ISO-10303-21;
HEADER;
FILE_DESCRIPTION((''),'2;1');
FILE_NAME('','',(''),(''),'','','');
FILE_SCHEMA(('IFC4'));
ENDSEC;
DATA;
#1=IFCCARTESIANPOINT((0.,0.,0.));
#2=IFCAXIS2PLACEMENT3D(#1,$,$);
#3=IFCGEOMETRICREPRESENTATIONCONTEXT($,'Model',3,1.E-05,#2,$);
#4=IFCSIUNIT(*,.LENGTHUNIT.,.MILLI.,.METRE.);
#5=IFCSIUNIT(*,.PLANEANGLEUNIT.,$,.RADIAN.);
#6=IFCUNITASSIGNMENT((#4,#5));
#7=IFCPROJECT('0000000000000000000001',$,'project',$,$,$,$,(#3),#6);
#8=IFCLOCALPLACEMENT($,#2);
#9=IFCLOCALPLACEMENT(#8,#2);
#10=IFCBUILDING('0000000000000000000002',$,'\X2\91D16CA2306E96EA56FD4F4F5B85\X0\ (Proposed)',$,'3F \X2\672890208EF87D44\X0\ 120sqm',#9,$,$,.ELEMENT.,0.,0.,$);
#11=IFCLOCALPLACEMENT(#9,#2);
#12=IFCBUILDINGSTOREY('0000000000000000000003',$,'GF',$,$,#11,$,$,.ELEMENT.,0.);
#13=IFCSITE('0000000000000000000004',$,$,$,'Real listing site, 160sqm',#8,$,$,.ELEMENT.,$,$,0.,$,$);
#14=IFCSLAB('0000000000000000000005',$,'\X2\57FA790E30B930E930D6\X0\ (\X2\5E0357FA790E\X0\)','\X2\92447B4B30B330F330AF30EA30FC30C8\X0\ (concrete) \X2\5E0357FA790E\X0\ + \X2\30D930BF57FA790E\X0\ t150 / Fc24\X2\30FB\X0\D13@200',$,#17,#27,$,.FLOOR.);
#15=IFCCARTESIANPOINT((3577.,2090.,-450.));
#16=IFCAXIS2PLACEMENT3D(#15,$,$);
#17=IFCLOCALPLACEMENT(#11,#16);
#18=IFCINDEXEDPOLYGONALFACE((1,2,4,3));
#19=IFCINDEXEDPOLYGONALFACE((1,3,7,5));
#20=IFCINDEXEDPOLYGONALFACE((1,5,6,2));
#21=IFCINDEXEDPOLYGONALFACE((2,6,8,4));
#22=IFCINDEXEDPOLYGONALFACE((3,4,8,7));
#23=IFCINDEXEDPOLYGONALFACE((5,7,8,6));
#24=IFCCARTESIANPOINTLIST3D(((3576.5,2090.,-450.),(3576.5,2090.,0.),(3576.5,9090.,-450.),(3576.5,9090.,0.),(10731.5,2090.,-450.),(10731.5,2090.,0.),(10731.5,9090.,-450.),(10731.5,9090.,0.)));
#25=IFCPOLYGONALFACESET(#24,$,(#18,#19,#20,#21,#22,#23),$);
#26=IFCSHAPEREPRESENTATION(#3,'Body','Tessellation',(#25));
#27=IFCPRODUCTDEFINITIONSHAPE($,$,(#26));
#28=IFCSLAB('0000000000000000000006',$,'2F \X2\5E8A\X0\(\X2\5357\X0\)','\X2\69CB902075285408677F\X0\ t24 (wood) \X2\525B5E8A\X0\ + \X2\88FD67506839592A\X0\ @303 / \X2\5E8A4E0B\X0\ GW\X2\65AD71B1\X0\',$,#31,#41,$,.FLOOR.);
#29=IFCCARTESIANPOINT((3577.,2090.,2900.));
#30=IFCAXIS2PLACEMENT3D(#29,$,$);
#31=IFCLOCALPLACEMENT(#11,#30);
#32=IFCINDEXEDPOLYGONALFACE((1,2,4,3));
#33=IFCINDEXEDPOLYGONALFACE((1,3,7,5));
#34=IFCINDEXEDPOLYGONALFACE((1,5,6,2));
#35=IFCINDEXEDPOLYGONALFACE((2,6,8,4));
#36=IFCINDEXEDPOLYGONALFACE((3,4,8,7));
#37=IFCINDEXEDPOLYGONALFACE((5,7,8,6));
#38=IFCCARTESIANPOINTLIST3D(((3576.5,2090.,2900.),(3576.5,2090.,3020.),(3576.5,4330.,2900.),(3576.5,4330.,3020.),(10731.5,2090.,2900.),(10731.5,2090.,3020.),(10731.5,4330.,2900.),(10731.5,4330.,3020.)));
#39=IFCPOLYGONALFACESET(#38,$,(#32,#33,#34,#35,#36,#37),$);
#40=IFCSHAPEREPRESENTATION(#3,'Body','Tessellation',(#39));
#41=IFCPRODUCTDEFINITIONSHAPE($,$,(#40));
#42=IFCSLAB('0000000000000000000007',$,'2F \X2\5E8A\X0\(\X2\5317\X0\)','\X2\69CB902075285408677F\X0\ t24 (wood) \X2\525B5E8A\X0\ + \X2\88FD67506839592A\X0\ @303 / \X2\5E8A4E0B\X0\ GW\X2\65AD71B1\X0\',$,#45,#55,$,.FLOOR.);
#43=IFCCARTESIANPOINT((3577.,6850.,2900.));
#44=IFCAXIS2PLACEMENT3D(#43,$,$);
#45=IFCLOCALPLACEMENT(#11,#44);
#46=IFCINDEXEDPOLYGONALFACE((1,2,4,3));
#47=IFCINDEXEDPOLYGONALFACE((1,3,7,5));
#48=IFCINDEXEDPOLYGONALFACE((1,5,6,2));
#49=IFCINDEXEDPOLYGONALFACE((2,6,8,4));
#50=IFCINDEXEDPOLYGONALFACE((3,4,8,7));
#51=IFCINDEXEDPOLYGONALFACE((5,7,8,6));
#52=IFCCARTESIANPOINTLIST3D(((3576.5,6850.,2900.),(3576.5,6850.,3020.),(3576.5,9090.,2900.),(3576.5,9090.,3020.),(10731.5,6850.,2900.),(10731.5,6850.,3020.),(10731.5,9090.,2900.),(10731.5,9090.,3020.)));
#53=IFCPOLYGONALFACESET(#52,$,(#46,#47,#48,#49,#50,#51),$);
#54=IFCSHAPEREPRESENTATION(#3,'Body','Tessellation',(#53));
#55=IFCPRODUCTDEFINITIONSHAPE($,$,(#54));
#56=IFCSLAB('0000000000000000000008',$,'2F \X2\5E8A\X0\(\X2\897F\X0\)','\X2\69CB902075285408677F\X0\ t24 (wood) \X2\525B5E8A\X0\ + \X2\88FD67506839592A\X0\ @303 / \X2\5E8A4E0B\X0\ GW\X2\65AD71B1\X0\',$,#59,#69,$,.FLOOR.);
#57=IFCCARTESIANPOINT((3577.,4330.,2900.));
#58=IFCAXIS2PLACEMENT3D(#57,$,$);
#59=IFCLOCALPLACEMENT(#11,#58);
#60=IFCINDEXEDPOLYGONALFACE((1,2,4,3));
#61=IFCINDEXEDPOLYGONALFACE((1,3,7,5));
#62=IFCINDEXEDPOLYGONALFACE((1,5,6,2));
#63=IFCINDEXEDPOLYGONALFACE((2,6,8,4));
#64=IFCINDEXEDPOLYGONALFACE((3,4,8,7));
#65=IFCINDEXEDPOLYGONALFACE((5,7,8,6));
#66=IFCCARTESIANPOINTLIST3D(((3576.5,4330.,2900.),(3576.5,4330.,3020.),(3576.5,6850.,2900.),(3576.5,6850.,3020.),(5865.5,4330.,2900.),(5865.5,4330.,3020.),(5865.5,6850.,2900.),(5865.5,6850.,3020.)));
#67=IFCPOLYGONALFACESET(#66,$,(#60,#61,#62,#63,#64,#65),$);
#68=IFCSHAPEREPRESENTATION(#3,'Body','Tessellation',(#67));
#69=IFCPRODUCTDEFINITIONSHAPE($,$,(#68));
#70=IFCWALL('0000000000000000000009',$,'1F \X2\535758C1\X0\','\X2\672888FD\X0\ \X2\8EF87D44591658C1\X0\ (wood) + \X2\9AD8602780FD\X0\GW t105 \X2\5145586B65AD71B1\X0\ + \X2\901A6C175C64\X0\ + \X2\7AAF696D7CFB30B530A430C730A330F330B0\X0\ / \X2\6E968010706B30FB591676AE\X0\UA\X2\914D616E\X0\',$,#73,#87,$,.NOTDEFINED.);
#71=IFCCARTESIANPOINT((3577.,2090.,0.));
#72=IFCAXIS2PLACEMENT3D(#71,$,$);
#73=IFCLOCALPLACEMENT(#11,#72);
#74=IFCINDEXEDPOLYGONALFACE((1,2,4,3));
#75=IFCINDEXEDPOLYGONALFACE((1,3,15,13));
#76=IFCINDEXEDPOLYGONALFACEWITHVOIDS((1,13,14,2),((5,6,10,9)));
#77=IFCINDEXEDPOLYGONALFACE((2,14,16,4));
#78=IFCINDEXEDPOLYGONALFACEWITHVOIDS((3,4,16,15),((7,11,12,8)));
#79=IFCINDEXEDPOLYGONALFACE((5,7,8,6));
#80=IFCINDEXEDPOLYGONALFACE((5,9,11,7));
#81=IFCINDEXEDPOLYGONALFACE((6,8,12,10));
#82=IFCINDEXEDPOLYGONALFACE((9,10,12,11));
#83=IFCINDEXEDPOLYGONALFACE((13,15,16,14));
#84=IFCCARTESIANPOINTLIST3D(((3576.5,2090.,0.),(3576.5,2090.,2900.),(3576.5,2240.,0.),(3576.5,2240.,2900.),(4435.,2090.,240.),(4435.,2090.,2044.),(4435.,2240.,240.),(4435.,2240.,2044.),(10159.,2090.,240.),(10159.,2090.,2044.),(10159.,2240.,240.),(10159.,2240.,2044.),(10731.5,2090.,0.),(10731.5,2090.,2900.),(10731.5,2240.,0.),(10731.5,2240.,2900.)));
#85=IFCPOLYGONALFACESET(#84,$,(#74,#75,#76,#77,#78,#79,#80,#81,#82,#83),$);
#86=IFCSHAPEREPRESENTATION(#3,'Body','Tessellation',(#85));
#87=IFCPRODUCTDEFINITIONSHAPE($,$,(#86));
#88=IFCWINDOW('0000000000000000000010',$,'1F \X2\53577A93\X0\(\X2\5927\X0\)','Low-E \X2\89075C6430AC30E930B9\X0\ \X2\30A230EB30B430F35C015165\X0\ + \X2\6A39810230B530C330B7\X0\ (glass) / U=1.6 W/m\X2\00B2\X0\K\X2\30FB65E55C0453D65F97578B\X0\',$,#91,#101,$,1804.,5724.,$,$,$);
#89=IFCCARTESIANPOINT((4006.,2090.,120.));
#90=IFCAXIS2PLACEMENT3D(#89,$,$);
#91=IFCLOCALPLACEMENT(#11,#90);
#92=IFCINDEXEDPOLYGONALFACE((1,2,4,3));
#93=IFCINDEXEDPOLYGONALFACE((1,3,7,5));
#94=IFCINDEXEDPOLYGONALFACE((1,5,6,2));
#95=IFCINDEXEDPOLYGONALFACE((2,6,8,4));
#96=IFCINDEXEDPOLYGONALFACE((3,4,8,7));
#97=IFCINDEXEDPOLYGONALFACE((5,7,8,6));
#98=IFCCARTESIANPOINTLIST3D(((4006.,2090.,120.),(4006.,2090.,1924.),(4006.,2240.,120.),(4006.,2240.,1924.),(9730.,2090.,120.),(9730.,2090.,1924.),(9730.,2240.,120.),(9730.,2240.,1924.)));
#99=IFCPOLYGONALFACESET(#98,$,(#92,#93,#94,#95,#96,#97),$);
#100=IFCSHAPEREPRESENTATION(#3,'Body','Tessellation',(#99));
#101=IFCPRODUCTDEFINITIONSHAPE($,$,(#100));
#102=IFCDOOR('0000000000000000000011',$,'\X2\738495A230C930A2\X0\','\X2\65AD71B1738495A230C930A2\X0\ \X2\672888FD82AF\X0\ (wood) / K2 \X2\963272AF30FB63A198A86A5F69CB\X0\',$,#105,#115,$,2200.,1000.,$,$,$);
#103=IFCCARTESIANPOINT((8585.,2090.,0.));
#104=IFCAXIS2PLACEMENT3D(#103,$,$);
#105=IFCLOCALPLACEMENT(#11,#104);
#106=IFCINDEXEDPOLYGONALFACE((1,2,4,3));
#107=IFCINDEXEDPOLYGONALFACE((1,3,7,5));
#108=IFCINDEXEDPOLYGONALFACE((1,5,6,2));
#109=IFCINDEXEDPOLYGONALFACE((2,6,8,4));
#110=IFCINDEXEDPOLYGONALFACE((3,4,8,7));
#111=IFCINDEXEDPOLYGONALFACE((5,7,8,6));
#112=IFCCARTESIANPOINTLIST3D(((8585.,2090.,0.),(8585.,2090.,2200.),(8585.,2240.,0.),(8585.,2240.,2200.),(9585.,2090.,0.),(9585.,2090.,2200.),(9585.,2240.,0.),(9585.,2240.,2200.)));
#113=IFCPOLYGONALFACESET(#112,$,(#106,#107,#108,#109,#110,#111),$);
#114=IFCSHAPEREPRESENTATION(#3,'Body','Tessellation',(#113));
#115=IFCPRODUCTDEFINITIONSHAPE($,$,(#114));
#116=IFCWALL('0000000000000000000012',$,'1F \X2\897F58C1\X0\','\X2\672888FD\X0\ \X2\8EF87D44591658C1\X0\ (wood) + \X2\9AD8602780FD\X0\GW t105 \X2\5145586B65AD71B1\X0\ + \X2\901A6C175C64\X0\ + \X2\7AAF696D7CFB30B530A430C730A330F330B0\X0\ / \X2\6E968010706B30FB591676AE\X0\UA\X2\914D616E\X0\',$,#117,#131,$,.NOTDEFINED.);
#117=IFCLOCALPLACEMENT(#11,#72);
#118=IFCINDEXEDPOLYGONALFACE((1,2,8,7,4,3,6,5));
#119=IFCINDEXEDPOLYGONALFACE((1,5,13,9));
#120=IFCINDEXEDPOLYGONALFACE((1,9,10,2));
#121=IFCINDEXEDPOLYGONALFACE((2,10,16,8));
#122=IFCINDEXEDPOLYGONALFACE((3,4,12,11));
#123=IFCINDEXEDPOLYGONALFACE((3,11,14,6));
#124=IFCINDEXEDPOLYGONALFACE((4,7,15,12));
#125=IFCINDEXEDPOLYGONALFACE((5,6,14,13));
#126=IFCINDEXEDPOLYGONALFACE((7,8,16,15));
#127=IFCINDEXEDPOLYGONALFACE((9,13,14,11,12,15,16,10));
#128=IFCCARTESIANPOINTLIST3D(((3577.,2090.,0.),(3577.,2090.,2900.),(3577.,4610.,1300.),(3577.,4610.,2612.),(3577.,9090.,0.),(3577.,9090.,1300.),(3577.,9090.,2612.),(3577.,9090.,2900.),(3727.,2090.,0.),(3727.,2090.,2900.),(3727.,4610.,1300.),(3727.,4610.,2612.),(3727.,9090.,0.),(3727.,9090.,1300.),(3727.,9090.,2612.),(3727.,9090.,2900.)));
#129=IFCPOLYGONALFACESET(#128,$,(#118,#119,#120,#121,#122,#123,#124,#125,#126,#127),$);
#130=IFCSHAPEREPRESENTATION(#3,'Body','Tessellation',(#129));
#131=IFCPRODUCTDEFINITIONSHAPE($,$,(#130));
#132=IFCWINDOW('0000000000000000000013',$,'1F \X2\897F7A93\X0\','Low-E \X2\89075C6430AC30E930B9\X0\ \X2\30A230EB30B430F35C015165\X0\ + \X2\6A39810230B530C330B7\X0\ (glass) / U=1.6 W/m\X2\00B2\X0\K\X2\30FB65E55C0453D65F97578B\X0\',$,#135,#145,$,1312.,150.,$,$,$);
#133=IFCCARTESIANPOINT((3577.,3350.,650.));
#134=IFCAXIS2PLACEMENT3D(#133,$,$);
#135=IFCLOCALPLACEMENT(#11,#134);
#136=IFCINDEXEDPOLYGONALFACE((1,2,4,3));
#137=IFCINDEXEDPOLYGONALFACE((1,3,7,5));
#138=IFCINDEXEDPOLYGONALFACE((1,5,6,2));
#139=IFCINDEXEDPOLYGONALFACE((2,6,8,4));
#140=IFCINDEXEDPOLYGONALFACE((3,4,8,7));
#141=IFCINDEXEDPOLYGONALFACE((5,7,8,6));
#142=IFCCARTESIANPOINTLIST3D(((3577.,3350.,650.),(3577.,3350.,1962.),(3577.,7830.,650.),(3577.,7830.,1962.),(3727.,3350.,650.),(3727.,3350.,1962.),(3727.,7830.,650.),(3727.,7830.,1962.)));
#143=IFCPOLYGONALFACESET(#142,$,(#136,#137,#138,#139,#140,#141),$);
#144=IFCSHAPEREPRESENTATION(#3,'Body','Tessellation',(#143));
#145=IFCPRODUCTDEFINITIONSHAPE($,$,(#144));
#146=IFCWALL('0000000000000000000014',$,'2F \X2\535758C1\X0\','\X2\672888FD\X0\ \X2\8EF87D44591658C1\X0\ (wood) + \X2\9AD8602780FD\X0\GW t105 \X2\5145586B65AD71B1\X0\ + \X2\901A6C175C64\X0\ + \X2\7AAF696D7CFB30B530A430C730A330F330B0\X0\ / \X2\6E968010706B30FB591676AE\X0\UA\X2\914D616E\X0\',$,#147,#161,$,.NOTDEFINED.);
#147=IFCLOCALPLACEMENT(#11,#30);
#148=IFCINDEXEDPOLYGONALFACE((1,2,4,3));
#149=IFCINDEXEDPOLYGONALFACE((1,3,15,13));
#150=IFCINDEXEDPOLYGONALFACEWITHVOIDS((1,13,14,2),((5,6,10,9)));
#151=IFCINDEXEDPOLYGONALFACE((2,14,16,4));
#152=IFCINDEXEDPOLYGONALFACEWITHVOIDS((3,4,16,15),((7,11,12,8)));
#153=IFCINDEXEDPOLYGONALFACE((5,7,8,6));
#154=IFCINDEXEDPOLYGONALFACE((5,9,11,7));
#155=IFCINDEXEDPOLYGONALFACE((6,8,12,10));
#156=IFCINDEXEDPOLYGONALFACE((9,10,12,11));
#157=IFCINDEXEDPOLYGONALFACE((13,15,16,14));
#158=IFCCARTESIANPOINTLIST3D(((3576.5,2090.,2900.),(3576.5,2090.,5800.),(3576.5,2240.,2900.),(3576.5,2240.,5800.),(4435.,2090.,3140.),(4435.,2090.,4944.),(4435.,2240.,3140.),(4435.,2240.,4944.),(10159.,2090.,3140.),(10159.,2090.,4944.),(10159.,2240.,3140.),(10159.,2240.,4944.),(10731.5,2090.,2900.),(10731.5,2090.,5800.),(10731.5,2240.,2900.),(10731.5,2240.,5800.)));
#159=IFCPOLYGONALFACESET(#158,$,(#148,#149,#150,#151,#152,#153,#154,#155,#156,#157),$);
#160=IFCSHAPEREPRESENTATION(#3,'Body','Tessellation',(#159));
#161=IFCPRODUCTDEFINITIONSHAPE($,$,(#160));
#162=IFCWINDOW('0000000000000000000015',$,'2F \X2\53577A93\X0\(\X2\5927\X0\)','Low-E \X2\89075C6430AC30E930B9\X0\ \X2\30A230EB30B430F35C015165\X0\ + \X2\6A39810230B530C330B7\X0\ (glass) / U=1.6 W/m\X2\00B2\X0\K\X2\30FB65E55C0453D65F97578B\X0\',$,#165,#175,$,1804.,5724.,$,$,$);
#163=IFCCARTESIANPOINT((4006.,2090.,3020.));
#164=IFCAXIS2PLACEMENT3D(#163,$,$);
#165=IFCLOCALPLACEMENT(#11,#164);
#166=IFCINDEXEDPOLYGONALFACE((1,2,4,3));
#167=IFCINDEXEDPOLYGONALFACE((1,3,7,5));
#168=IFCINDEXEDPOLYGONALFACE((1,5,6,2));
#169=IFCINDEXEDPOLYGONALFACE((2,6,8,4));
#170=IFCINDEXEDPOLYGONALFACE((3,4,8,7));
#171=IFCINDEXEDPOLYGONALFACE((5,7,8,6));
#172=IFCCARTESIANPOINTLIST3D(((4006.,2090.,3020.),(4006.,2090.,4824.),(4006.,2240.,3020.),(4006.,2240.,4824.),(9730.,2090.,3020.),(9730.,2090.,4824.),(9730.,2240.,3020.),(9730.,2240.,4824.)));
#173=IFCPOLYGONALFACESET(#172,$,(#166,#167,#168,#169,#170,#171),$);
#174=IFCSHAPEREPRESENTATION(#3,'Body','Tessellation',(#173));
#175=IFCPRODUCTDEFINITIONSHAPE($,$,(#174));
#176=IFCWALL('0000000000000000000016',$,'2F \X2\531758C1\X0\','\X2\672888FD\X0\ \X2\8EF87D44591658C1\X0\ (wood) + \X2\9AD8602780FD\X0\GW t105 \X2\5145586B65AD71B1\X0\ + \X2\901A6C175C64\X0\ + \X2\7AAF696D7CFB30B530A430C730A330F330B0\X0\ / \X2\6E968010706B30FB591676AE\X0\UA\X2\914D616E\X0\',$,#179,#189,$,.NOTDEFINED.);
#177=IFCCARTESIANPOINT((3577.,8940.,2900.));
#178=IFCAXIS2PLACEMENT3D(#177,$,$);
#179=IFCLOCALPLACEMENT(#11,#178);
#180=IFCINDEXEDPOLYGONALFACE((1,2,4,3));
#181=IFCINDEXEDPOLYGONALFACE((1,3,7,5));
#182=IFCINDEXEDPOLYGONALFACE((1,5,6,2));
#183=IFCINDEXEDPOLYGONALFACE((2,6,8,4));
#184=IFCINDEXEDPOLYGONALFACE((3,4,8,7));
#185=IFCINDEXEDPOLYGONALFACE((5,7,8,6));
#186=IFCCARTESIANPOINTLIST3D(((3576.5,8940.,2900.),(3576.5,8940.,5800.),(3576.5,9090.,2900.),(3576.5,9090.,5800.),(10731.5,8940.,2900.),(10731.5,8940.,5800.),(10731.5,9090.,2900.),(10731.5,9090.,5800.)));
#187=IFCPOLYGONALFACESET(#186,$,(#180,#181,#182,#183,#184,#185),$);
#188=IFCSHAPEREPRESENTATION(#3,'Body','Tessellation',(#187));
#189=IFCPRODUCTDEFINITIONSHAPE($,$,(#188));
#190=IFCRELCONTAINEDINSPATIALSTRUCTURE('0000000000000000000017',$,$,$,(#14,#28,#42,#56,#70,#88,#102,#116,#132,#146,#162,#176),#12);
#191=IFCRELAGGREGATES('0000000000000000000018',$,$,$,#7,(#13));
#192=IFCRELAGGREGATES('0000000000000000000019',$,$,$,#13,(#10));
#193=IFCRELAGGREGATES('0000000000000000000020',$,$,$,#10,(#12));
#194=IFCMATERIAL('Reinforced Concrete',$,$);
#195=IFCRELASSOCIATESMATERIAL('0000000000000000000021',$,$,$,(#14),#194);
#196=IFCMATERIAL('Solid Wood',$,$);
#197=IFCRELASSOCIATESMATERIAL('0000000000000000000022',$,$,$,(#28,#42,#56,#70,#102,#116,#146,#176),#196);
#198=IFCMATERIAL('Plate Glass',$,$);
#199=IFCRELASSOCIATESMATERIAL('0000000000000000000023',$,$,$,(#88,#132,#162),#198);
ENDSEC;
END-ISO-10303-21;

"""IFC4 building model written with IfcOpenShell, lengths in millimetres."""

from ifc_helpers import new_model, si_unit, frame, frame_2d, origin, place, context, project, spatial, rectangle, extrude, material, element, fill, save


model = new_model("IFC4")

# Units and contexts
model_context = context("Model", 3, precision=1e-05, world=origin())
ifc_project = project(units=[si_unit("LENGTHUNIT", "METRE", prefix="MILLI"), si_unit("PLANEANGLEUNIT", "RADIAN")], contexts=[model_context])

# Site, building, storey
site_placement = place(None, origin())
site = spatial("IfcSite", under=ifc_project, at=site_placement, ObjectType="Real listing site, 160sqm", CompositionType="ELEMENT", RefElevation=0.0)
building_placement = place(site_placement, origin())
building = spatial("IfcBuilding", under=site, at=building_placement, Name="金沢の雪国住宅 (Proposed)", ObjectType="3F 木造軸組 120sqm", CompositionType="ELEMENT", ElevationOfRefHeight=0.0, ElevationOfTerrain=0.0)
storey_placement = place(building_placement, origin())
storey = spatial("IfcBuildingStorey", under=building, at=storey_placement, Name="GF", CompositionType="ELEMENT", Elevation=0.0)

# Slabs
ifc_material_1 = material(Name="Reinforced Concrete")
slab_1_placement = place(storey_placement, frame((3577.0, 2090.0, -450.0)))
element("IfcSlab", 1, at=slab_1_placement, inside=storey, material=ifc_material_1, Name="基礎スラブ (布基礎)", Description="鉄筋コンクリート (concrete) 布基礎 + ベタ基礎 t150 / Fc24・D13@200", PredefinedType="FLOOR", context=model_context, shape_type="SweptSolid", body=[
    extrude(rectangle(XDim=7155.0, YDim=7000.0, at=frame_2d((3577.0, 3500.0))), frame((3577.0, 2090.0, -450.0)), (0.0, 0.0, 1.0), 450.0),
])
ifc_material_2 = material(Name="Solid Wood")
slab_2_placement = place(storey_placement, frame((3577.0, 2090.0, 2900.0)))
element("IfcSlab", 2, at=slab_2_placement, inside=storey, material=ifc_material_2, Name="2F 床(南)", Description="構造用合板 t24 (wood) 剛床 + 製材根太 @303 / 床下 GW断熱", PredefinedType="FLOOR", context=model_context, shape_type="SweptSolid", body=[
    extrude(rectangle(XDim=7155.0, YDim=2240.0, at=frame_2d((3577.0, 1120.0))), frame((3577.0, 2090.0, 2900.0)), (0.0, 0.0, 1.0), 120.0),
])
slab_3_placement = place(storey_placement, frame((3577.0, 6850.0, 2900.0)))
element("IfcSlab", 3, at=slab_3_placement, inside=storey, material=ifc_material_2, Name="2F 床(北)", Description="構造用合板 t24 (wood) 剛床 + 製材根太 @303 / 床下 GW断熱", PredefinedType="FLOOR", context=model_context, shape_type="SweptSolid", body=[
    extrude(rectangle(XDim=7155.0, YDim=2240.0, at=frame_2d((3577.0, 1120.0))), frame((3577.0, 6850.0, 2900.0)), (0.0, 0.0, 1.0), 120.0),
])
slab_4_placement = place(storey_placement, frame((3577.0, 4330.0, 2900.0)))
element("IfcSlab", 4, at=slab_4_placement, inside=storey, material=ifc_material_2, Name="2F 床(西)", Description="構造用合板 t24 (wood) 剛床 + 製材根太 @303 / 床下 GW断熱", PredefinedType="FLOOR", context=model_context, shape_type="SweptSolid", body=[
    extrude(rectangle(XDim=2289.0, YDim=2520.0, at=frame_2d((1144.0, 1260.0))), frame((3577.0, 4330.0, 2900.0)), (0.0, 0.0, 1.0), 120.0),
])

# Wall, openings, window, door
wall_1_placement = place(storey_placement, frame((3577.0, 2090.0, 0.0)))
wall_1 = element("IfcWall", 5, at=wall_1_placement, inside=storey, material=ifc_material_2, Name="1F 南壁", Description="木製 軸組外壁 (wood) + 高性能GW t105 充填断熱 + 通気層 + 窯業系サイディング / 準耐火・外皮UA配慮", PredefinedType="NOTDEFINED", context=model_context, shape_type="SweptSolid", body=[
    extrude(rectangle(XDim=7155.0, YDim=150.0, at=frame_2d((3577.0, 75.0))), frame((3577.0, 2090.0, 0.0)), (0.0, 0.0, 1.0), 2900.0),
])
opening_1_placement = place(storey_placement, frame((4006.0, 2090.0, 120.0)))
opening_1 = element("IfcOpeningElement", 6, at=opening_1_placement, cuts=wall_1, PredefinedType="NOTDEFINED", context=model_context, shape_type="SweptSolid", body=[
    extrude(rectangle(XDim=5724.0, YDim=150.0, at=frame_2d((2862.0, 75.0))), frame((4006.0, 2090.0, 120.0)), (0.0, 0.0, 1.0), 1804.0),
])
opening_2_placement = place(storey_placement, frame((8585.0, 2090.0, 0.0)))
opening_2 = element("IfcOpeningElement", 7, at=opening_2_placement, cuts=wall_1, PredefinedType="NOTDEFINED", context=model_context, shape_type="SweptSolid", body=[
    extrude(rectangle(XDim=1000.0, YDim=150.0, at=frame_2d((500.0, 75.0))), frame((8585.0, 2090.0, 0.0)), (0.0, 0.0, 1.0), 2200.0),
])
ifc_material_3 = material(Name="Plate Glass")
window_1_placement = place(storey_placement, frame((4006.0, 2090.0, 120.0)))
window_1 = element("IfcWindow", 8, at=window_1_placement, inside=storey, material=ifc_material_3, Name="1F 南窓(大)", Description="Low-E 複層ガラス アルゴン封入 + 樹脂サッシ (glass) / U=1.6 W/m²K・日射取得型", OverallHeight=1804.0, OverallWidth=5724.0, context=model_context, shape_type="SweptSolid", body=[
    extrude(rectangle(XDim=5724.0, YDim=150.0, at=frame_2d((2862.0, 75.0))), frame((4006.0, 2090.0, 120.0)), (0.0, 0.0, 1.0), 1804.0),
])
fill(opening_1, window_1)
door_placement = place(storey_placement, frame((8585.0, 2090.0, 0.0)))
door = element("IfcDoor", 9, at=door_placement, inside=storey, material=ifc_material_2, Name="玄関ドア", Description="断熱玄関ドア 木製芯 (wood) / K2 防犯・採風機構", OverallHeight=2200.0, OverallWidth=1000.0, context=model_context, shape_type="SweptSolid", body=[
    extrude(rectangle(XDim=1000.0, YDim=150.0, at=frame_2d((500.0, 75.0))), frame((8585.0, 2090.0, 0.0)), (0.0, 0.0, 1.0), 2200.0),
])
fill(opening_2, door)

# Walls, openings, windows
wall_2_placement = place(storey_placement, frame((3577.0, 2090.0, 0.0)))
wall_2 = element("IfcWall", 10, at=wall_2_placement, inside=storey, material=ifc_material_2, Name="1F 西壁", Description="木製 軸組外壁 (wood) + 高性能GW t105 充填断熱 + 通気層 + 窯業系サイディング / 準耐火・外皮UA配慮", PredefinedType="NOTDEFINED", context=model_context, shape_type="SweptSolid", body=[
    extrude(rectangle(XDim=150.0, YDim=7000.0, at=frame_2d((75.0, 3500.0))), frame((3577.0, 2090.0, 0.0)), (0.0, 0.0, 1.0), 2900.0),
])
opening_3_placement = place(storey_placement, frame((3577.0, 3350.0, 650.0)))
opening_3 = element("IfcOpeningElement", 11, at=opening_3_placement, cuts=wall_2, PredefinedType="NOTDEFINED", context=model_context, shape_type="SweptSolid", body=[
    extrude(rectangle(XDim=150.0, YDim=4480.0, at=frame_2d((75.0, 2240.0))), frame((3577.0, 3350.0, 650.0)), (0.0, 0.0, 1.0), 1312.0),
])
window_2_placement = place(storey_placement, frame((3577.0, 3350.0, 650.0)))
window_2 = element("IfcWindow", 12, at=window_2_placement, inside=storey, material=ifc_material_3, Name="1F 西窓", Description="Low-E 複層ガラス アルゴン封入 + 樹脂サッシ (glass) / U=1.6 W/m²K・日射取得型", OverallHeight=1312.0, OverallWidth=150.0, context=model_context, shape_type="SweptSolid", body=[
    extrude(rectangle(XDim=150.0, YDim=4480.0, at=frame_2d((75.0, 2240.0))), frame((3577.0, 3350.0, 650.0)), (0.0, 0.0, 1.0), 1312.0),
])
fill(opening_3, window_2)
wall_3_placement = place(storey_placement, frame((3577.0, 2090.0, 2900.0)))
wall_3 = element("IfcWall", 13, at=wall_3_placement, inside=storey, material=ifc_material_2, Name="2F 南壁", Description="木製 軸組外壁 (wood) + 高性能GW t105 充填断熱 + 通気層 + 窯業系サイディング / 準耐火・外皮UA配慮", PredefinedType="NOTDEFINED", context=model_context, shape_type="SweptSolid", body=[
    extrude(rectangle(XDim=7155.0, YDim=150.0, at=frame_2d((3577.0, 75.0))), frame((3577.0, 2090.0, 2900.0)), (0.0, 0.0, 1.0), 2900.0),
])
opening_4_placement = place(storey_placement, frame((4006.0, 2090.0, 3020.0)))
opening_4 = element("IfcOpeningElement", 14, at=opening_4_placement, cuts=wall_3, PredefinedType="NOTDEFINED", context=model_context, shape_type="SweptSolid", body=[
    extrude(rectangle(XDim=5724.0, YDim=150.0, at=frame_2d((2862.0, 75.0))), frame((4006.0, 2090.0, 3020.0)), (0.0, 0.0, 1.0), 1804.0),
])
window_3_placement = place(storey_placement, frame((4006.0, 2090.0, 3020.0)))
window_3 = element("IfcWindow", 15, at=window_3_placement, inside=storey, material=ifc_material_3, Name="2F 南窓(大)", Description="Low-E 複層ガラス アルゴン封入 + 樹脂サッシ (glass) / U=1.6 W/m²K・日射取得型", OverallHeight=1804.0, OverallWidth=5724.0, context=model_context, shape_type="SweptSolid", body=[
    extrude(rectangle(XDim=5724.0, YDim=150.0, at=frame_2d((2862.0, 75.0))), frame((4006.0, 2090.0, 3020.0)), (0.0, 0.0, 1.0), 1804.0),
])
fill(opening_4, window_3)

# Wall
wall_4_placement = place(storey_placement, frame((3577.0, 8940.0, 2900.0)))
element("IfcWall", 16, at=wall_4_placement, inside=storey, material=ifc_material_2, Name="2F 北壁", Description="木製 軸組外壁 (wood) + 高性能GW t105 充填断熱 + 通気層 + 窯業系サイディング / 準耐火・外皮UA配慮", PredefinedType="NOTDEFINED", context=model_context, shape_type="SweptSolid", body=[
    extrude(rectangle(XDim=7155.0, YDim=150.0, at=frame_2d((3577.0, 75.0))), frame((3577.0, 8940.0, 2900.0)), (0.0, 0.0, 1.0), 2900.0),
])

save(model, "model.ifc")
